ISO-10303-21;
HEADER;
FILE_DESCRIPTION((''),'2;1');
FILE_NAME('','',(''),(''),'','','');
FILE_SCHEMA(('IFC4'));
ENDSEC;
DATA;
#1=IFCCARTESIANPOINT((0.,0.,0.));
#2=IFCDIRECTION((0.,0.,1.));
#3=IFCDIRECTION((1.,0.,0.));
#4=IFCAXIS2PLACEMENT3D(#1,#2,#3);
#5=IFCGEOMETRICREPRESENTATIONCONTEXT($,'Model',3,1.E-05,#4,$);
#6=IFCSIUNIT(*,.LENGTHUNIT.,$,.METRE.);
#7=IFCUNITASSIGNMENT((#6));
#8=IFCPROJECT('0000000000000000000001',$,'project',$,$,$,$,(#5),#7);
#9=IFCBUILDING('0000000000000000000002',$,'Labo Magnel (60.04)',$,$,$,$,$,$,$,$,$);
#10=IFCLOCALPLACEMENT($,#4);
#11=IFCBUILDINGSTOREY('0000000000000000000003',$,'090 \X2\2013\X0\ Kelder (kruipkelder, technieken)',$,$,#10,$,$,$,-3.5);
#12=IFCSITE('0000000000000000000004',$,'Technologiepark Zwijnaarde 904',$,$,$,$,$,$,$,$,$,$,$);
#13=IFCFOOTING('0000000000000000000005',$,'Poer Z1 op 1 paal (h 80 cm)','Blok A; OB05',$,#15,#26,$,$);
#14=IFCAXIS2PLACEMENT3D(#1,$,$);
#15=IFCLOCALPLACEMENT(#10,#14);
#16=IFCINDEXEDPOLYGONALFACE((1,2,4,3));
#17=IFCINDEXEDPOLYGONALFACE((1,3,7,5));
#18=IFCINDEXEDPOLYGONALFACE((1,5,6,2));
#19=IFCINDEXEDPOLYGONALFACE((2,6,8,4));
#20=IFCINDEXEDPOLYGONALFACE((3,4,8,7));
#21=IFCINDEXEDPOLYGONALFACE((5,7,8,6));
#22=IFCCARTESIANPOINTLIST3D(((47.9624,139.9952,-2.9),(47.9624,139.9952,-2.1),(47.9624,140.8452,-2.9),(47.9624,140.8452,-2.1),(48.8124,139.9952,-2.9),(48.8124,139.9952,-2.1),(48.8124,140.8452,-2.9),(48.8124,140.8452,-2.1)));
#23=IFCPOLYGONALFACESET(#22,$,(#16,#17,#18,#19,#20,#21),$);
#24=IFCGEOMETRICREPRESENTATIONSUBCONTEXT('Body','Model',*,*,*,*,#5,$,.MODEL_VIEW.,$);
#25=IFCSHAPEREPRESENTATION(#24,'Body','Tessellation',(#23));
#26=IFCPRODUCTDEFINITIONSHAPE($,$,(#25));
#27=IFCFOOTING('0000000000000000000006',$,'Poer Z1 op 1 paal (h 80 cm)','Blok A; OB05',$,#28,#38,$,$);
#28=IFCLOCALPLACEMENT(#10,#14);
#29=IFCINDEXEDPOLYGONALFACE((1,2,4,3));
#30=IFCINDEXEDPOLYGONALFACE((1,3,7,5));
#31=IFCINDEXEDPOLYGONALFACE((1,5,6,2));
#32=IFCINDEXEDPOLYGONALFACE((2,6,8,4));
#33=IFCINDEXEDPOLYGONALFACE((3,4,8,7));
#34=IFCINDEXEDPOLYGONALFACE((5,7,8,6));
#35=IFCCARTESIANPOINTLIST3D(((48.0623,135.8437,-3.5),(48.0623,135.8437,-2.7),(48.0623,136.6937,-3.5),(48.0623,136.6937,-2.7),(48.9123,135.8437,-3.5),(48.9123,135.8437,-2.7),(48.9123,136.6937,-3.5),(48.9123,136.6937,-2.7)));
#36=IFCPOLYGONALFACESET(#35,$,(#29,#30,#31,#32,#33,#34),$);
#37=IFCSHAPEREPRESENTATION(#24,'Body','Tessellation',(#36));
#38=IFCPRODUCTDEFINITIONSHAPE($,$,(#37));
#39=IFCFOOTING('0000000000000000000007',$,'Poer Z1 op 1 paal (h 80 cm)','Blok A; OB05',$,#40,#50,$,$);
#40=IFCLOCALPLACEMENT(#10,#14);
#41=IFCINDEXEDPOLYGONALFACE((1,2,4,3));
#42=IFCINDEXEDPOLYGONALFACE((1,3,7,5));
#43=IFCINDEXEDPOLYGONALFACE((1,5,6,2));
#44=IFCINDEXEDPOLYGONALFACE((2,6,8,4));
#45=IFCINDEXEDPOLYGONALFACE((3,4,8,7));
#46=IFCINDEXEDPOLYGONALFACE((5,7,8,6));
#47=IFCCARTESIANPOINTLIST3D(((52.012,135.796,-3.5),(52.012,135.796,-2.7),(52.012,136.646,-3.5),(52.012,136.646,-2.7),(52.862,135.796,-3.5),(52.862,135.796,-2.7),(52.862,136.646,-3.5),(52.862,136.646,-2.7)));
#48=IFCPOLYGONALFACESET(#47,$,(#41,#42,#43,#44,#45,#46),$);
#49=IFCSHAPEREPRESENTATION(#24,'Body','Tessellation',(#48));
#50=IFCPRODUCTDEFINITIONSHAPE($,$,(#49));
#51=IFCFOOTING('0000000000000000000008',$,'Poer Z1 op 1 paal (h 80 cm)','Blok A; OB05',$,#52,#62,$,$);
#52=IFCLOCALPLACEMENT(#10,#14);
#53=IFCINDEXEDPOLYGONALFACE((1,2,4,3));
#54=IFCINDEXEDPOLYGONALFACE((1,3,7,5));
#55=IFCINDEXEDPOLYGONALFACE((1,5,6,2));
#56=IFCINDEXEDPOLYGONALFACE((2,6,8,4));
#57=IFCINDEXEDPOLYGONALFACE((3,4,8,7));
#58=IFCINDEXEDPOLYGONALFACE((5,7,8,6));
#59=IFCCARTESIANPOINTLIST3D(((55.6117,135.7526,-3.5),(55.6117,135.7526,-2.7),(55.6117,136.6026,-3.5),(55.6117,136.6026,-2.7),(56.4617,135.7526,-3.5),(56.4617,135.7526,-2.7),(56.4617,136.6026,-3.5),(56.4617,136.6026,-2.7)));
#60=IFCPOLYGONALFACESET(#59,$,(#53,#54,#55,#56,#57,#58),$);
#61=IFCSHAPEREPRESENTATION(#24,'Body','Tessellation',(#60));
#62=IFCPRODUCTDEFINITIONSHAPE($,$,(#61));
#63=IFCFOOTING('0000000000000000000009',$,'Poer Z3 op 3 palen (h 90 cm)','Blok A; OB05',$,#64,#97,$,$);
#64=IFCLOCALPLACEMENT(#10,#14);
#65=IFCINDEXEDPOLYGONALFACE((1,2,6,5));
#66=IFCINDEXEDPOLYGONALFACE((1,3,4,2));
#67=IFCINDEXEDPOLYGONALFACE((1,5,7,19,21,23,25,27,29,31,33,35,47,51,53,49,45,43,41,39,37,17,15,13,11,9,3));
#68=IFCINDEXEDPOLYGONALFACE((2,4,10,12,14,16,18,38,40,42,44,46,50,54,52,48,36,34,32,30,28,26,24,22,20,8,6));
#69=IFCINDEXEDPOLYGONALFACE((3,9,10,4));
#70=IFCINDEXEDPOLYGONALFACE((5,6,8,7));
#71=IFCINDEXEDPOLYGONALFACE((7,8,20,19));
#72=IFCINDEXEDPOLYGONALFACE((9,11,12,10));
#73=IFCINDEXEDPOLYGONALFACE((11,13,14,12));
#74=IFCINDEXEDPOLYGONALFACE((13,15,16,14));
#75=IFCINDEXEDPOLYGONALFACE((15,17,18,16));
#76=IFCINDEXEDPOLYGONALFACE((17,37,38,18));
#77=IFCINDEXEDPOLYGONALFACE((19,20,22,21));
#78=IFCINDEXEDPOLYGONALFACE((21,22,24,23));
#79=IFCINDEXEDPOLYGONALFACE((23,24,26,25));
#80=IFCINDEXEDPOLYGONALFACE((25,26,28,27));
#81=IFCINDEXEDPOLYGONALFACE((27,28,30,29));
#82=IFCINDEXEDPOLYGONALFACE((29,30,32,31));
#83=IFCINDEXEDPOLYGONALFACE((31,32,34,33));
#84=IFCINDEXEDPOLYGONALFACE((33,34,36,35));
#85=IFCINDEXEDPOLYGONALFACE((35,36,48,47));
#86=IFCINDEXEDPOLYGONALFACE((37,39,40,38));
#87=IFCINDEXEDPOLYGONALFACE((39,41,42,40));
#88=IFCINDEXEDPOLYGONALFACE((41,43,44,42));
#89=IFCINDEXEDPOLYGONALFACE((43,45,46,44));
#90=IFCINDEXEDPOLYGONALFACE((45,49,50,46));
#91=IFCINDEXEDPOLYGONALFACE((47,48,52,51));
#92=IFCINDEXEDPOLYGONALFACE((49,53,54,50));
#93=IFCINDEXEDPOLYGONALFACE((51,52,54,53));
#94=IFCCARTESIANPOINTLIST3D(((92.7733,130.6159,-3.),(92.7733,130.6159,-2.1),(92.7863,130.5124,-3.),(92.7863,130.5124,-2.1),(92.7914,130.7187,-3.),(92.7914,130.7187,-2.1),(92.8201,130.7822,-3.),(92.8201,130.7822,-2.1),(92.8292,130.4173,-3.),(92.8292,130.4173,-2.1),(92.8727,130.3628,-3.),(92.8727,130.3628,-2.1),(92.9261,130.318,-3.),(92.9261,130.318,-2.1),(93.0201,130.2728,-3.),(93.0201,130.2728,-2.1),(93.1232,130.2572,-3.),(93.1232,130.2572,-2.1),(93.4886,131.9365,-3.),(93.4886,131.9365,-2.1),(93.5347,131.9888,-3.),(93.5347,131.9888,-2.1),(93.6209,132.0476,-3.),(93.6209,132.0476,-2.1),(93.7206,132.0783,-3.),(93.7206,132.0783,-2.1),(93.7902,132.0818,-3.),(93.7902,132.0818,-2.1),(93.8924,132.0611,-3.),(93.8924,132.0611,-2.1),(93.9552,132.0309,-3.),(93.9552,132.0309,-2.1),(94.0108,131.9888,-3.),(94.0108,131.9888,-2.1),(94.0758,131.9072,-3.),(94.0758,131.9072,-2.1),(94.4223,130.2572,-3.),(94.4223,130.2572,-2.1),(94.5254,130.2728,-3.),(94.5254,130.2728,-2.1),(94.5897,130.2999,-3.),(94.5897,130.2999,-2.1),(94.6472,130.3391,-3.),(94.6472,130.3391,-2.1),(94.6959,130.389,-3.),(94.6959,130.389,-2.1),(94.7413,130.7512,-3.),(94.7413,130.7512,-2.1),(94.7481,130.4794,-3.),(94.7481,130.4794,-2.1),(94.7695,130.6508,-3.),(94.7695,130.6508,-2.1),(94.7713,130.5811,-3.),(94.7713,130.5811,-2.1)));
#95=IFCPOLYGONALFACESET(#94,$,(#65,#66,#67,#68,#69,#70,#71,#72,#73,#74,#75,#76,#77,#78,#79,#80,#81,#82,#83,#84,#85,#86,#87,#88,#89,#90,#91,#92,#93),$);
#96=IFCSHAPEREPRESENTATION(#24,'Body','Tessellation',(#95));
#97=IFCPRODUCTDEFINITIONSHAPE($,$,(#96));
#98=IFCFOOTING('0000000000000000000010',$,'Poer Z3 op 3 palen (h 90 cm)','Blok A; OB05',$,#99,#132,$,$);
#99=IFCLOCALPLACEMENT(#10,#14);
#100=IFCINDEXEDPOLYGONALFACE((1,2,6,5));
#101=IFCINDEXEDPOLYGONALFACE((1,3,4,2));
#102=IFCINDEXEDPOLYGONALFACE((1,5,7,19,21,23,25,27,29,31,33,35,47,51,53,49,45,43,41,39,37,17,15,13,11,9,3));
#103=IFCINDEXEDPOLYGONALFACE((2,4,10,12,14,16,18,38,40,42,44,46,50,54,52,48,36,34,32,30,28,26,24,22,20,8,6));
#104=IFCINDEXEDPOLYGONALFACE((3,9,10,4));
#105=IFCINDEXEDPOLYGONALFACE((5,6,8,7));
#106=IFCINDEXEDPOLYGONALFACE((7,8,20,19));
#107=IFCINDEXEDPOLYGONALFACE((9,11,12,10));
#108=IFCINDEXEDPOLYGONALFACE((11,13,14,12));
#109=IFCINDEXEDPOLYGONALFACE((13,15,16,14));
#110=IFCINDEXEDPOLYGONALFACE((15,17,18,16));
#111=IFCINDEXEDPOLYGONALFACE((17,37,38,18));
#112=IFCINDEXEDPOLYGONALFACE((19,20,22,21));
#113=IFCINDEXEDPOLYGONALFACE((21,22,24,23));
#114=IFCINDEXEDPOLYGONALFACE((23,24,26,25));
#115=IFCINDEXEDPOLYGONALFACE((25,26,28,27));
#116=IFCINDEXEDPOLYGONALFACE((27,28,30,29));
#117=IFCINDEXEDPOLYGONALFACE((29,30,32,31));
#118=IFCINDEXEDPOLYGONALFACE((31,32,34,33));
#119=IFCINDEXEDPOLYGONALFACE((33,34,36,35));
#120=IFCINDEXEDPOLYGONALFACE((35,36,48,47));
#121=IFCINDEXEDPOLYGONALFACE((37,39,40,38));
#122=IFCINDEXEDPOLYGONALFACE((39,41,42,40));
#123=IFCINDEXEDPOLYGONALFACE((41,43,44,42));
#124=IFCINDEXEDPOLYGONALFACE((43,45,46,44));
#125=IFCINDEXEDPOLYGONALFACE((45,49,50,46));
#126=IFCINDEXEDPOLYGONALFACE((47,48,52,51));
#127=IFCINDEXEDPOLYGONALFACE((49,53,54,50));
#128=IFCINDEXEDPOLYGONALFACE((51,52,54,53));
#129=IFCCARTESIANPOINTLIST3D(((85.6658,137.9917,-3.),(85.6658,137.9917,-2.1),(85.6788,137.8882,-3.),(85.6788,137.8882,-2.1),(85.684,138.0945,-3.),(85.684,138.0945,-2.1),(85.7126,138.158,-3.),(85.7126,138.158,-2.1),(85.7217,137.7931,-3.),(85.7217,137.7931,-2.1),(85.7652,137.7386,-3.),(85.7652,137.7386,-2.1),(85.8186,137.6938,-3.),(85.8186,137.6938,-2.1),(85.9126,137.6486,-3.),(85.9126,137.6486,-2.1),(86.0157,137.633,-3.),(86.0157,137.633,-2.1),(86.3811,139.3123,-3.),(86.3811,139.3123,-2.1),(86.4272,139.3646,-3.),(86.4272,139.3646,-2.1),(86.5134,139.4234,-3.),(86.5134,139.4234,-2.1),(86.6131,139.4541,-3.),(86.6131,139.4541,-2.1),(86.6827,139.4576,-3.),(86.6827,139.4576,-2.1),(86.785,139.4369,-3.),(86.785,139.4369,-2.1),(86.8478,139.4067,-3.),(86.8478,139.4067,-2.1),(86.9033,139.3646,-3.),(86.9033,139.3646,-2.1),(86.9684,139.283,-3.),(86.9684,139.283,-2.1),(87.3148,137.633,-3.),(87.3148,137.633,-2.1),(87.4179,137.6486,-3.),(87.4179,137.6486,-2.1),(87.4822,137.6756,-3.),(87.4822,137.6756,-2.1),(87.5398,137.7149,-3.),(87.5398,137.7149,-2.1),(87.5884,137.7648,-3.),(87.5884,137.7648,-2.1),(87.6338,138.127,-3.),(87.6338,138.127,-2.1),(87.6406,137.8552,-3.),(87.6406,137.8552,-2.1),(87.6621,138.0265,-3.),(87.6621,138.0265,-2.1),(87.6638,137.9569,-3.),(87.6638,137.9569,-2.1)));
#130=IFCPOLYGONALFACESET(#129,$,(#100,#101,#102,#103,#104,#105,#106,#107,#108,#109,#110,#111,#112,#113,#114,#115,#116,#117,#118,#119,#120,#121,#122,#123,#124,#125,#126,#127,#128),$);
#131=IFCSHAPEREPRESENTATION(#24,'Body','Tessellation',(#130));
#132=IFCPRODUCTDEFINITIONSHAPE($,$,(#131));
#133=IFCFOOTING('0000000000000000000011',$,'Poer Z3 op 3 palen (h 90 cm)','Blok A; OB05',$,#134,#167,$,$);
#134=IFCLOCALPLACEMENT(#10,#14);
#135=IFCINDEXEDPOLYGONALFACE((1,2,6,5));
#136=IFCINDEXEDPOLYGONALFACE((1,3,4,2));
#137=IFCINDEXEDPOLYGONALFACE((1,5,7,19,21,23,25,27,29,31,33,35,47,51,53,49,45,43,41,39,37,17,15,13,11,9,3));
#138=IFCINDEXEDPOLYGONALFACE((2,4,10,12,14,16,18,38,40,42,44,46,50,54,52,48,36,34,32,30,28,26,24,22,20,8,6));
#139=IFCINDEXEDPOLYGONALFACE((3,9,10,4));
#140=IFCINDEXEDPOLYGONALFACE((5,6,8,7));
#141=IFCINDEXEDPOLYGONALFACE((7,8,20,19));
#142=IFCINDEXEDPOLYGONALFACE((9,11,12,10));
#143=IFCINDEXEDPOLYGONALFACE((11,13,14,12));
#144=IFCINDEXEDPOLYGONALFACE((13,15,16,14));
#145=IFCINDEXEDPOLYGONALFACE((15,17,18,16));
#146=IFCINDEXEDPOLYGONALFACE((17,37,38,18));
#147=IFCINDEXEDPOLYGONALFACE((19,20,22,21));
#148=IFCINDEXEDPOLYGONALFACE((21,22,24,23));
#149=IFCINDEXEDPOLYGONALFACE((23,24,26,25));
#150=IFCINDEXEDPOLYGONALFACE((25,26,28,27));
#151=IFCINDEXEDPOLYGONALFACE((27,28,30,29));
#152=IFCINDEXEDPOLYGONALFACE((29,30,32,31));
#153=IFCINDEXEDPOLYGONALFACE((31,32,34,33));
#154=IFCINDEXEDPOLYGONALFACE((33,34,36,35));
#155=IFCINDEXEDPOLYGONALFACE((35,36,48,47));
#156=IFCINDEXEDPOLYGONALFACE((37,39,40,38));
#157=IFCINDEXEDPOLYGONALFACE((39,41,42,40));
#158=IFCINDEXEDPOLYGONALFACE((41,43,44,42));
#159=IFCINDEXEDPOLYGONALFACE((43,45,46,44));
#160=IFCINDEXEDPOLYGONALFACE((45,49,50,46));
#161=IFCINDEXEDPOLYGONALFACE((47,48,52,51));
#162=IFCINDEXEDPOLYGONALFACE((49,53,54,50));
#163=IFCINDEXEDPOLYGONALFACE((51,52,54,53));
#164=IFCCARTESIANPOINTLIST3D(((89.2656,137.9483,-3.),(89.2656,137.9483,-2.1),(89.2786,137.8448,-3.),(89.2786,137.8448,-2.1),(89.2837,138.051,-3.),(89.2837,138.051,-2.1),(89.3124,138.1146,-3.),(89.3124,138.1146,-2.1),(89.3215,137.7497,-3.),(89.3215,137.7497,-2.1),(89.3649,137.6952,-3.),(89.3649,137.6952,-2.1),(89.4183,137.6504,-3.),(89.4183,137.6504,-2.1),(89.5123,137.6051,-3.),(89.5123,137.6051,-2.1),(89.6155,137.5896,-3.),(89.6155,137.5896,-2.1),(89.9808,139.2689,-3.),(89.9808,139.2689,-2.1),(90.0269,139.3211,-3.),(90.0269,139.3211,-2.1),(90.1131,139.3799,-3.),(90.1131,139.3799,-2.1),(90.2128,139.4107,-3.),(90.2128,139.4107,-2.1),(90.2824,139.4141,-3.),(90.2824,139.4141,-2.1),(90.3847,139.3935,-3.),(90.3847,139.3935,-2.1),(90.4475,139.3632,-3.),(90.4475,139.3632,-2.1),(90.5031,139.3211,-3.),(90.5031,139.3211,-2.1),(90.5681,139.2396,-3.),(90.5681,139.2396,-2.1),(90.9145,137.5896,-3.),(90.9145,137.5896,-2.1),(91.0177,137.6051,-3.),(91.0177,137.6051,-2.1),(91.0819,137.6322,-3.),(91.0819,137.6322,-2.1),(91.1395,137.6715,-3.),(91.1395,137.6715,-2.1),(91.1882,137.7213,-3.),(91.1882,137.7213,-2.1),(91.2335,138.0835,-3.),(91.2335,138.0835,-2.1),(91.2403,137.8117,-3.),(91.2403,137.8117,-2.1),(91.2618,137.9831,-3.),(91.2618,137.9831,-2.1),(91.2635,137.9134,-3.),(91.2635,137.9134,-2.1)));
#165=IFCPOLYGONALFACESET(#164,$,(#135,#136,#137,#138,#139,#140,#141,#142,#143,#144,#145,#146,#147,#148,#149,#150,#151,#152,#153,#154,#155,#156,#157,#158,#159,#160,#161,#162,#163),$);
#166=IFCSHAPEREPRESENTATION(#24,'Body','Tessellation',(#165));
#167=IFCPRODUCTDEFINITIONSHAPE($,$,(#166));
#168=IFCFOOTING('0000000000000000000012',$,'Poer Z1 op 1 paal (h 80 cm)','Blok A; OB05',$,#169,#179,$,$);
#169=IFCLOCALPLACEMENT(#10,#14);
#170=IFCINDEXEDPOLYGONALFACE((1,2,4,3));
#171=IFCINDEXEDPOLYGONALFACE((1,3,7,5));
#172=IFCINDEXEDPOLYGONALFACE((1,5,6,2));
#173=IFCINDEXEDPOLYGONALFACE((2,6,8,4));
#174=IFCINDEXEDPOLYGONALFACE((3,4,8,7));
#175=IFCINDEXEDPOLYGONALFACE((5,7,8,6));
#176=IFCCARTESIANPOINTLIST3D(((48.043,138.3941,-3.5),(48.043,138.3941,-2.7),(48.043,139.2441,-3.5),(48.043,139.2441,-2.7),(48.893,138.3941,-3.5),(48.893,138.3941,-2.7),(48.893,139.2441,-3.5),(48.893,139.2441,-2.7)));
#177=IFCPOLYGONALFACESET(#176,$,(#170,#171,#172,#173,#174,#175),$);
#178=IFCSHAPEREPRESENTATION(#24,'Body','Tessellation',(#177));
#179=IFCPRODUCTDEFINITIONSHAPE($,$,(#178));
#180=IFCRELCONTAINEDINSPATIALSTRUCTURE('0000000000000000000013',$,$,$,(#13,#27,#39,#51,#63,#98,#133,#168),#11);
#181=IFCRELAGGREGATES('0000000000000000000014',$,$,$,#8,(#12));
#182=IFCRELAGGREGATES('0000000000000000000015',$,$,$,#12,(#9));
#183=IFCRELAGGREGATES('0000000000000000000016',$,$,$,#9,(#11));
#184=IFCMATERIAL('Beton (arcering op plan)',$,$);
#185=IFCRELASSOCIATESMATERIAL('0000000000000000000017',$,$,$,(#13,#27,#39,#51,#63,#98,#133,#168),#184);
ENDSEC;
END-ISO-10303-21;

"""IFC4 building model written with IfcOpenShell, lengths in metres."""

from ifc_helpers import new_model, si_unit, frame, origin, origin_with_axes, place, context, subcontext, project, spatial, polyline, outline, extrude, material, element, save


model = new_model("IFC4")

# Units and contexts
model_context = context("Model", 3, precision=1e-05, world=origin_with_axes())
body_context = subcontext(model_context, "Body", "Model", "MODEL_VIEW")
ifc_project = project(units=[si_unit("LENGTHUNIT", "METRE")], contexts=[model_context])

# Site, building, storey
site = spatial("IfcSite", under=ifc_project, Name="Technologiepark Zwijnaarde 904")
building = spatial("IfcBuilding", under=site, Name="Labo Magnel (60.04)")
storey_placement = place(None, origin_with_axes())
storey = spatial("IfcBuildingStorey", under=building, at=storey_placement, Name="090 – Kelder (kruipkelder, technieken)", Elevation=-3.5)

# Footings
ifc_material_1 = material(Name="Beton (arcering op plan)")
footing_1_placement = place(storey_placement, frame((0.0, 0.0, -2.9), z_axis=(0.0, 0.0, 1.0), x_axis=(1.0, 0.0, 0.0)))
element("IfcFooting", 1, at=footing_1_placement, inside=storey, material=ifc_material_1, Name="Poer Z1 op 1 paal (h 80 cm)", Description="Blok A; OB05", context=body_context, shape_type="SweptSolid", body=[
    extrude(outline(polyline([(48.8124, 140.8452), (48.8124, 139.9952), (47.9624, 139.9952), (47.9624, 140.8452), (48.8124, 140.8452)])), origin(), (0.0, 0.0, 1.0), 0.8),
])
footing_2_placement = place(storey_placement, frame((0.0, 0.0, -3.5), z_axis=(0.0, 0.0, 1.0), x_axis=(1.0, 0.0, 0.0)))
element("IfcFooting", 2, at=footing_2_placement, inside=storey, material=ifc_material_1, Name="Poer Z1 op 1 paal (h 80 cm)", Description="Blok A; OB05", context=body_context, shape_type="SweptSolid", body=[
    extrude(outline(polyline([(48.9123, 136.6937), (48.9123, 135.8437), (48.0623, 135.8437), (48.0623, 136.6937), (48.9123, 136.6937)])), origin(), (0.0, 0.0, 1.0), 0.8),
])
footing_3_placement = place(storey_placement, frame((0.0, 0.0, -3.5), z_axis=(0.0, 0.0, 1.0), x_axis=(1.0, 0.0, 0.0)))
element("IfcFooting", 3, at=footing_3_placement, inside=storey, material=ifc_material_1, Name="Poer Z1 op 1 paal (h 80 cm)", Description="Blok A; OB05", context=body_context, shape_type="SweptSolid", body=[
    extrude(outline(polyline([(52.862, 136.646), (52.862, 135.796), (52.012, 135.796), (52.012, 136.646), (52.862, 136.646)])), origin(), (0.0, 0.0, 1.0), 0.8),
])
footing_4_placement = place(storey_placement, frame((0.0, 0.0, -3.5), z_axis=(0.0, 0.0, 1.0), x_axis=(1.0, 0.0, 0.0)))
element("IfcFooting", 4, at=footing_4_placement, inside=storey, material=ifc_material_1, Name="Poer Z1 op 1 paal (h 80 cm)", Description="Blok A; OB05", context=body_context, shape_type="SweptSolid", body=[
    extrude(outline(polyline([(56.4617, 136.6026), (56.4617, 135.7526), (55.6117, 135.7526), (55.6117, 136.6026), (56.4617, 136.6026)])), origin(), (0.0, 0.0, 1.0), 0.8),
])
footing_5_placement = place(storey_placement, frame((0.0, 0.0, -3.0), z_axis=(0.0, 0.0, 1.0), x_axis=(1.0, 0.0, 0.0)))
element("IfcFooting", 5, at=footing_5_placement, inside=storey, material=ifc_material_1, Name="Poer Z3 op 3 palen (h 90 cm)", Description="Blok A; OB05", context=body_context, shape_type="SweptSolid", body=[
    extrude(outline(polyline([(94.0758, 131.9072), (94.7413, 130.7512), (94.7695, 130.6508), (94.7713, 130.5811), (94.7481, 130.4794), (94.6959, 130.389), (94.6472, 130.3391), (94.5897, 130.2999), (94.5254, 130.2728), (94.4223, 130.2572), (93.1232, 130.2572), (93.0201, 130.2728), (92.9261, 130.318), (92.8727, 130.3628), (92.8292, 130.4173), (92.7863, 130.5124), (92.7733, 130.6159), (92.7914, 130.7187), (92.8201, 130.7822), (93.4886, 131.9365), (93.5347, 131.9888), (93.6209, 132.0476), (93.7206, 132.0783), (93.7902, 132.0818), (93.8924, 132.0611), (93.9552, 132.0309), (94.0108, 131.9888), (94.0758, 131.9072)])), origin(), (0.0, 0.0, 1.0), 0.9),
])
footing_6_placement = place(storey_placement, frame((0.0, 0.0, -3.0), z_axis=(0.0, 0.0, 1.0), x_axis=(1.0, 0.0, 0.0)))
element("IfcFooting", 6, at=footing_6_placement, inside=storey, material=ifc_material_1, Name="Poer Z3 op 3 palen (h 90 cm)", Description="Blok A; OB05", context=body_context, shape_type="SweptSolid", body=[
    extrude(outline(polyline([(86.9684, 139.283), (87.6338, 138.127), (87.6621, 138.0265), (87.6638, 137.9569), (87.6406, 137.8552), (87.5884, 137.7648), (87.5398, 137.7149), (87.4822, 137.6756), (87.4179, 137.6486), (87.3148, 137.633), (86.0157, 137.633), (85.9126, 137.6486), (85.8186, 137.6938), (85.7652, 137.7386), (85.7217, 137.7931), (85.6788, 137.8882), (85.6658, 137.9917), (85.684, 138.0945), (85.7126, 138.158), (86.3811, 139.3123), (86.4272, 139.3646), (86.5134, 139.4234), (86.6131, 139.4541), (86.6827, 139.4576), (86.785, 139.4369), (86.8478, 139.4067), (86.9033, 139.3646), (86.9684, 139.283)])), origin(), (0.0, 0.0, 1.0), 0.9),
])
footing_7_placement = place(storey_placement, frame((0.0, 0.0, -3.0), z_axis=(0.0, 0.0, 1.0), x_axis=(1.0, 0.0, 0.0)))
element("IfcFooting", 7, at=footing_7_placement, inside=storey, material=ifc_material_1, Name="Poer Z3 op 3 palen (h 90 cm)", Description="Blok A; OB05", context=body_context, shape_type="SweptSolid", body=[
    extrude(outline(polyline([(90.5681, 139.2396), (91.2335, 138.0835), (91.2618, 137.9831), (91.2635, 137.9134), (91.2403, 137.8117), (91.1882, 137.7213), (91.1395, 137.6715), (91.0819, 137.6322), (91.0177, 137.6051), (90.9145, 137.5896), (89.6155, 137.5896), (89.5123, 137.6051), (89.4183, 137.6504), (89.3649, 137.6952), (89.3215, 137.7497), (89.2786, 137.8448), (89.2656, 137.9483), (89.2837, 138.051), (89.3124, 138.1146), (89.9808, 139.2689), (90.0269, 139.3211), (90.1131, 139.3799), (90.2128, 139.4107), (90.2824, 139.4141), (90.3847, 139.3935), (90.4475, 139.3632), (90.5031, 139.3211), (90.5681, 139.2396)])), origin(), (0.0, 0.0, 1.0), 0.9),
])
footing_8_placement = place(storey_placement, frame((0.0, 0.0, -3.5), z_axis=(0.0, 0.0, 1.0), x_axis=(1.0, 0.0, 0.0)))
element("IfcFooting", 8, at=footing_8_placement, inside=storey, material=ifc_material_1, Name="Poer Z1 op 1 paal (h 80 cm)", Description="Blok A; OB05", context=body_context, shape_type="SweptSolid", body=[
    extrude(outline(polyline([(48.893, 139.2441), (48.893, 138.3941), (48.043, 138.3941), (48.043, 139.2441), (48.893, 139.2441)])), origin(), (0.0, 0.0, 1.0), 0.8),
])

save(model, "model.ifc")
